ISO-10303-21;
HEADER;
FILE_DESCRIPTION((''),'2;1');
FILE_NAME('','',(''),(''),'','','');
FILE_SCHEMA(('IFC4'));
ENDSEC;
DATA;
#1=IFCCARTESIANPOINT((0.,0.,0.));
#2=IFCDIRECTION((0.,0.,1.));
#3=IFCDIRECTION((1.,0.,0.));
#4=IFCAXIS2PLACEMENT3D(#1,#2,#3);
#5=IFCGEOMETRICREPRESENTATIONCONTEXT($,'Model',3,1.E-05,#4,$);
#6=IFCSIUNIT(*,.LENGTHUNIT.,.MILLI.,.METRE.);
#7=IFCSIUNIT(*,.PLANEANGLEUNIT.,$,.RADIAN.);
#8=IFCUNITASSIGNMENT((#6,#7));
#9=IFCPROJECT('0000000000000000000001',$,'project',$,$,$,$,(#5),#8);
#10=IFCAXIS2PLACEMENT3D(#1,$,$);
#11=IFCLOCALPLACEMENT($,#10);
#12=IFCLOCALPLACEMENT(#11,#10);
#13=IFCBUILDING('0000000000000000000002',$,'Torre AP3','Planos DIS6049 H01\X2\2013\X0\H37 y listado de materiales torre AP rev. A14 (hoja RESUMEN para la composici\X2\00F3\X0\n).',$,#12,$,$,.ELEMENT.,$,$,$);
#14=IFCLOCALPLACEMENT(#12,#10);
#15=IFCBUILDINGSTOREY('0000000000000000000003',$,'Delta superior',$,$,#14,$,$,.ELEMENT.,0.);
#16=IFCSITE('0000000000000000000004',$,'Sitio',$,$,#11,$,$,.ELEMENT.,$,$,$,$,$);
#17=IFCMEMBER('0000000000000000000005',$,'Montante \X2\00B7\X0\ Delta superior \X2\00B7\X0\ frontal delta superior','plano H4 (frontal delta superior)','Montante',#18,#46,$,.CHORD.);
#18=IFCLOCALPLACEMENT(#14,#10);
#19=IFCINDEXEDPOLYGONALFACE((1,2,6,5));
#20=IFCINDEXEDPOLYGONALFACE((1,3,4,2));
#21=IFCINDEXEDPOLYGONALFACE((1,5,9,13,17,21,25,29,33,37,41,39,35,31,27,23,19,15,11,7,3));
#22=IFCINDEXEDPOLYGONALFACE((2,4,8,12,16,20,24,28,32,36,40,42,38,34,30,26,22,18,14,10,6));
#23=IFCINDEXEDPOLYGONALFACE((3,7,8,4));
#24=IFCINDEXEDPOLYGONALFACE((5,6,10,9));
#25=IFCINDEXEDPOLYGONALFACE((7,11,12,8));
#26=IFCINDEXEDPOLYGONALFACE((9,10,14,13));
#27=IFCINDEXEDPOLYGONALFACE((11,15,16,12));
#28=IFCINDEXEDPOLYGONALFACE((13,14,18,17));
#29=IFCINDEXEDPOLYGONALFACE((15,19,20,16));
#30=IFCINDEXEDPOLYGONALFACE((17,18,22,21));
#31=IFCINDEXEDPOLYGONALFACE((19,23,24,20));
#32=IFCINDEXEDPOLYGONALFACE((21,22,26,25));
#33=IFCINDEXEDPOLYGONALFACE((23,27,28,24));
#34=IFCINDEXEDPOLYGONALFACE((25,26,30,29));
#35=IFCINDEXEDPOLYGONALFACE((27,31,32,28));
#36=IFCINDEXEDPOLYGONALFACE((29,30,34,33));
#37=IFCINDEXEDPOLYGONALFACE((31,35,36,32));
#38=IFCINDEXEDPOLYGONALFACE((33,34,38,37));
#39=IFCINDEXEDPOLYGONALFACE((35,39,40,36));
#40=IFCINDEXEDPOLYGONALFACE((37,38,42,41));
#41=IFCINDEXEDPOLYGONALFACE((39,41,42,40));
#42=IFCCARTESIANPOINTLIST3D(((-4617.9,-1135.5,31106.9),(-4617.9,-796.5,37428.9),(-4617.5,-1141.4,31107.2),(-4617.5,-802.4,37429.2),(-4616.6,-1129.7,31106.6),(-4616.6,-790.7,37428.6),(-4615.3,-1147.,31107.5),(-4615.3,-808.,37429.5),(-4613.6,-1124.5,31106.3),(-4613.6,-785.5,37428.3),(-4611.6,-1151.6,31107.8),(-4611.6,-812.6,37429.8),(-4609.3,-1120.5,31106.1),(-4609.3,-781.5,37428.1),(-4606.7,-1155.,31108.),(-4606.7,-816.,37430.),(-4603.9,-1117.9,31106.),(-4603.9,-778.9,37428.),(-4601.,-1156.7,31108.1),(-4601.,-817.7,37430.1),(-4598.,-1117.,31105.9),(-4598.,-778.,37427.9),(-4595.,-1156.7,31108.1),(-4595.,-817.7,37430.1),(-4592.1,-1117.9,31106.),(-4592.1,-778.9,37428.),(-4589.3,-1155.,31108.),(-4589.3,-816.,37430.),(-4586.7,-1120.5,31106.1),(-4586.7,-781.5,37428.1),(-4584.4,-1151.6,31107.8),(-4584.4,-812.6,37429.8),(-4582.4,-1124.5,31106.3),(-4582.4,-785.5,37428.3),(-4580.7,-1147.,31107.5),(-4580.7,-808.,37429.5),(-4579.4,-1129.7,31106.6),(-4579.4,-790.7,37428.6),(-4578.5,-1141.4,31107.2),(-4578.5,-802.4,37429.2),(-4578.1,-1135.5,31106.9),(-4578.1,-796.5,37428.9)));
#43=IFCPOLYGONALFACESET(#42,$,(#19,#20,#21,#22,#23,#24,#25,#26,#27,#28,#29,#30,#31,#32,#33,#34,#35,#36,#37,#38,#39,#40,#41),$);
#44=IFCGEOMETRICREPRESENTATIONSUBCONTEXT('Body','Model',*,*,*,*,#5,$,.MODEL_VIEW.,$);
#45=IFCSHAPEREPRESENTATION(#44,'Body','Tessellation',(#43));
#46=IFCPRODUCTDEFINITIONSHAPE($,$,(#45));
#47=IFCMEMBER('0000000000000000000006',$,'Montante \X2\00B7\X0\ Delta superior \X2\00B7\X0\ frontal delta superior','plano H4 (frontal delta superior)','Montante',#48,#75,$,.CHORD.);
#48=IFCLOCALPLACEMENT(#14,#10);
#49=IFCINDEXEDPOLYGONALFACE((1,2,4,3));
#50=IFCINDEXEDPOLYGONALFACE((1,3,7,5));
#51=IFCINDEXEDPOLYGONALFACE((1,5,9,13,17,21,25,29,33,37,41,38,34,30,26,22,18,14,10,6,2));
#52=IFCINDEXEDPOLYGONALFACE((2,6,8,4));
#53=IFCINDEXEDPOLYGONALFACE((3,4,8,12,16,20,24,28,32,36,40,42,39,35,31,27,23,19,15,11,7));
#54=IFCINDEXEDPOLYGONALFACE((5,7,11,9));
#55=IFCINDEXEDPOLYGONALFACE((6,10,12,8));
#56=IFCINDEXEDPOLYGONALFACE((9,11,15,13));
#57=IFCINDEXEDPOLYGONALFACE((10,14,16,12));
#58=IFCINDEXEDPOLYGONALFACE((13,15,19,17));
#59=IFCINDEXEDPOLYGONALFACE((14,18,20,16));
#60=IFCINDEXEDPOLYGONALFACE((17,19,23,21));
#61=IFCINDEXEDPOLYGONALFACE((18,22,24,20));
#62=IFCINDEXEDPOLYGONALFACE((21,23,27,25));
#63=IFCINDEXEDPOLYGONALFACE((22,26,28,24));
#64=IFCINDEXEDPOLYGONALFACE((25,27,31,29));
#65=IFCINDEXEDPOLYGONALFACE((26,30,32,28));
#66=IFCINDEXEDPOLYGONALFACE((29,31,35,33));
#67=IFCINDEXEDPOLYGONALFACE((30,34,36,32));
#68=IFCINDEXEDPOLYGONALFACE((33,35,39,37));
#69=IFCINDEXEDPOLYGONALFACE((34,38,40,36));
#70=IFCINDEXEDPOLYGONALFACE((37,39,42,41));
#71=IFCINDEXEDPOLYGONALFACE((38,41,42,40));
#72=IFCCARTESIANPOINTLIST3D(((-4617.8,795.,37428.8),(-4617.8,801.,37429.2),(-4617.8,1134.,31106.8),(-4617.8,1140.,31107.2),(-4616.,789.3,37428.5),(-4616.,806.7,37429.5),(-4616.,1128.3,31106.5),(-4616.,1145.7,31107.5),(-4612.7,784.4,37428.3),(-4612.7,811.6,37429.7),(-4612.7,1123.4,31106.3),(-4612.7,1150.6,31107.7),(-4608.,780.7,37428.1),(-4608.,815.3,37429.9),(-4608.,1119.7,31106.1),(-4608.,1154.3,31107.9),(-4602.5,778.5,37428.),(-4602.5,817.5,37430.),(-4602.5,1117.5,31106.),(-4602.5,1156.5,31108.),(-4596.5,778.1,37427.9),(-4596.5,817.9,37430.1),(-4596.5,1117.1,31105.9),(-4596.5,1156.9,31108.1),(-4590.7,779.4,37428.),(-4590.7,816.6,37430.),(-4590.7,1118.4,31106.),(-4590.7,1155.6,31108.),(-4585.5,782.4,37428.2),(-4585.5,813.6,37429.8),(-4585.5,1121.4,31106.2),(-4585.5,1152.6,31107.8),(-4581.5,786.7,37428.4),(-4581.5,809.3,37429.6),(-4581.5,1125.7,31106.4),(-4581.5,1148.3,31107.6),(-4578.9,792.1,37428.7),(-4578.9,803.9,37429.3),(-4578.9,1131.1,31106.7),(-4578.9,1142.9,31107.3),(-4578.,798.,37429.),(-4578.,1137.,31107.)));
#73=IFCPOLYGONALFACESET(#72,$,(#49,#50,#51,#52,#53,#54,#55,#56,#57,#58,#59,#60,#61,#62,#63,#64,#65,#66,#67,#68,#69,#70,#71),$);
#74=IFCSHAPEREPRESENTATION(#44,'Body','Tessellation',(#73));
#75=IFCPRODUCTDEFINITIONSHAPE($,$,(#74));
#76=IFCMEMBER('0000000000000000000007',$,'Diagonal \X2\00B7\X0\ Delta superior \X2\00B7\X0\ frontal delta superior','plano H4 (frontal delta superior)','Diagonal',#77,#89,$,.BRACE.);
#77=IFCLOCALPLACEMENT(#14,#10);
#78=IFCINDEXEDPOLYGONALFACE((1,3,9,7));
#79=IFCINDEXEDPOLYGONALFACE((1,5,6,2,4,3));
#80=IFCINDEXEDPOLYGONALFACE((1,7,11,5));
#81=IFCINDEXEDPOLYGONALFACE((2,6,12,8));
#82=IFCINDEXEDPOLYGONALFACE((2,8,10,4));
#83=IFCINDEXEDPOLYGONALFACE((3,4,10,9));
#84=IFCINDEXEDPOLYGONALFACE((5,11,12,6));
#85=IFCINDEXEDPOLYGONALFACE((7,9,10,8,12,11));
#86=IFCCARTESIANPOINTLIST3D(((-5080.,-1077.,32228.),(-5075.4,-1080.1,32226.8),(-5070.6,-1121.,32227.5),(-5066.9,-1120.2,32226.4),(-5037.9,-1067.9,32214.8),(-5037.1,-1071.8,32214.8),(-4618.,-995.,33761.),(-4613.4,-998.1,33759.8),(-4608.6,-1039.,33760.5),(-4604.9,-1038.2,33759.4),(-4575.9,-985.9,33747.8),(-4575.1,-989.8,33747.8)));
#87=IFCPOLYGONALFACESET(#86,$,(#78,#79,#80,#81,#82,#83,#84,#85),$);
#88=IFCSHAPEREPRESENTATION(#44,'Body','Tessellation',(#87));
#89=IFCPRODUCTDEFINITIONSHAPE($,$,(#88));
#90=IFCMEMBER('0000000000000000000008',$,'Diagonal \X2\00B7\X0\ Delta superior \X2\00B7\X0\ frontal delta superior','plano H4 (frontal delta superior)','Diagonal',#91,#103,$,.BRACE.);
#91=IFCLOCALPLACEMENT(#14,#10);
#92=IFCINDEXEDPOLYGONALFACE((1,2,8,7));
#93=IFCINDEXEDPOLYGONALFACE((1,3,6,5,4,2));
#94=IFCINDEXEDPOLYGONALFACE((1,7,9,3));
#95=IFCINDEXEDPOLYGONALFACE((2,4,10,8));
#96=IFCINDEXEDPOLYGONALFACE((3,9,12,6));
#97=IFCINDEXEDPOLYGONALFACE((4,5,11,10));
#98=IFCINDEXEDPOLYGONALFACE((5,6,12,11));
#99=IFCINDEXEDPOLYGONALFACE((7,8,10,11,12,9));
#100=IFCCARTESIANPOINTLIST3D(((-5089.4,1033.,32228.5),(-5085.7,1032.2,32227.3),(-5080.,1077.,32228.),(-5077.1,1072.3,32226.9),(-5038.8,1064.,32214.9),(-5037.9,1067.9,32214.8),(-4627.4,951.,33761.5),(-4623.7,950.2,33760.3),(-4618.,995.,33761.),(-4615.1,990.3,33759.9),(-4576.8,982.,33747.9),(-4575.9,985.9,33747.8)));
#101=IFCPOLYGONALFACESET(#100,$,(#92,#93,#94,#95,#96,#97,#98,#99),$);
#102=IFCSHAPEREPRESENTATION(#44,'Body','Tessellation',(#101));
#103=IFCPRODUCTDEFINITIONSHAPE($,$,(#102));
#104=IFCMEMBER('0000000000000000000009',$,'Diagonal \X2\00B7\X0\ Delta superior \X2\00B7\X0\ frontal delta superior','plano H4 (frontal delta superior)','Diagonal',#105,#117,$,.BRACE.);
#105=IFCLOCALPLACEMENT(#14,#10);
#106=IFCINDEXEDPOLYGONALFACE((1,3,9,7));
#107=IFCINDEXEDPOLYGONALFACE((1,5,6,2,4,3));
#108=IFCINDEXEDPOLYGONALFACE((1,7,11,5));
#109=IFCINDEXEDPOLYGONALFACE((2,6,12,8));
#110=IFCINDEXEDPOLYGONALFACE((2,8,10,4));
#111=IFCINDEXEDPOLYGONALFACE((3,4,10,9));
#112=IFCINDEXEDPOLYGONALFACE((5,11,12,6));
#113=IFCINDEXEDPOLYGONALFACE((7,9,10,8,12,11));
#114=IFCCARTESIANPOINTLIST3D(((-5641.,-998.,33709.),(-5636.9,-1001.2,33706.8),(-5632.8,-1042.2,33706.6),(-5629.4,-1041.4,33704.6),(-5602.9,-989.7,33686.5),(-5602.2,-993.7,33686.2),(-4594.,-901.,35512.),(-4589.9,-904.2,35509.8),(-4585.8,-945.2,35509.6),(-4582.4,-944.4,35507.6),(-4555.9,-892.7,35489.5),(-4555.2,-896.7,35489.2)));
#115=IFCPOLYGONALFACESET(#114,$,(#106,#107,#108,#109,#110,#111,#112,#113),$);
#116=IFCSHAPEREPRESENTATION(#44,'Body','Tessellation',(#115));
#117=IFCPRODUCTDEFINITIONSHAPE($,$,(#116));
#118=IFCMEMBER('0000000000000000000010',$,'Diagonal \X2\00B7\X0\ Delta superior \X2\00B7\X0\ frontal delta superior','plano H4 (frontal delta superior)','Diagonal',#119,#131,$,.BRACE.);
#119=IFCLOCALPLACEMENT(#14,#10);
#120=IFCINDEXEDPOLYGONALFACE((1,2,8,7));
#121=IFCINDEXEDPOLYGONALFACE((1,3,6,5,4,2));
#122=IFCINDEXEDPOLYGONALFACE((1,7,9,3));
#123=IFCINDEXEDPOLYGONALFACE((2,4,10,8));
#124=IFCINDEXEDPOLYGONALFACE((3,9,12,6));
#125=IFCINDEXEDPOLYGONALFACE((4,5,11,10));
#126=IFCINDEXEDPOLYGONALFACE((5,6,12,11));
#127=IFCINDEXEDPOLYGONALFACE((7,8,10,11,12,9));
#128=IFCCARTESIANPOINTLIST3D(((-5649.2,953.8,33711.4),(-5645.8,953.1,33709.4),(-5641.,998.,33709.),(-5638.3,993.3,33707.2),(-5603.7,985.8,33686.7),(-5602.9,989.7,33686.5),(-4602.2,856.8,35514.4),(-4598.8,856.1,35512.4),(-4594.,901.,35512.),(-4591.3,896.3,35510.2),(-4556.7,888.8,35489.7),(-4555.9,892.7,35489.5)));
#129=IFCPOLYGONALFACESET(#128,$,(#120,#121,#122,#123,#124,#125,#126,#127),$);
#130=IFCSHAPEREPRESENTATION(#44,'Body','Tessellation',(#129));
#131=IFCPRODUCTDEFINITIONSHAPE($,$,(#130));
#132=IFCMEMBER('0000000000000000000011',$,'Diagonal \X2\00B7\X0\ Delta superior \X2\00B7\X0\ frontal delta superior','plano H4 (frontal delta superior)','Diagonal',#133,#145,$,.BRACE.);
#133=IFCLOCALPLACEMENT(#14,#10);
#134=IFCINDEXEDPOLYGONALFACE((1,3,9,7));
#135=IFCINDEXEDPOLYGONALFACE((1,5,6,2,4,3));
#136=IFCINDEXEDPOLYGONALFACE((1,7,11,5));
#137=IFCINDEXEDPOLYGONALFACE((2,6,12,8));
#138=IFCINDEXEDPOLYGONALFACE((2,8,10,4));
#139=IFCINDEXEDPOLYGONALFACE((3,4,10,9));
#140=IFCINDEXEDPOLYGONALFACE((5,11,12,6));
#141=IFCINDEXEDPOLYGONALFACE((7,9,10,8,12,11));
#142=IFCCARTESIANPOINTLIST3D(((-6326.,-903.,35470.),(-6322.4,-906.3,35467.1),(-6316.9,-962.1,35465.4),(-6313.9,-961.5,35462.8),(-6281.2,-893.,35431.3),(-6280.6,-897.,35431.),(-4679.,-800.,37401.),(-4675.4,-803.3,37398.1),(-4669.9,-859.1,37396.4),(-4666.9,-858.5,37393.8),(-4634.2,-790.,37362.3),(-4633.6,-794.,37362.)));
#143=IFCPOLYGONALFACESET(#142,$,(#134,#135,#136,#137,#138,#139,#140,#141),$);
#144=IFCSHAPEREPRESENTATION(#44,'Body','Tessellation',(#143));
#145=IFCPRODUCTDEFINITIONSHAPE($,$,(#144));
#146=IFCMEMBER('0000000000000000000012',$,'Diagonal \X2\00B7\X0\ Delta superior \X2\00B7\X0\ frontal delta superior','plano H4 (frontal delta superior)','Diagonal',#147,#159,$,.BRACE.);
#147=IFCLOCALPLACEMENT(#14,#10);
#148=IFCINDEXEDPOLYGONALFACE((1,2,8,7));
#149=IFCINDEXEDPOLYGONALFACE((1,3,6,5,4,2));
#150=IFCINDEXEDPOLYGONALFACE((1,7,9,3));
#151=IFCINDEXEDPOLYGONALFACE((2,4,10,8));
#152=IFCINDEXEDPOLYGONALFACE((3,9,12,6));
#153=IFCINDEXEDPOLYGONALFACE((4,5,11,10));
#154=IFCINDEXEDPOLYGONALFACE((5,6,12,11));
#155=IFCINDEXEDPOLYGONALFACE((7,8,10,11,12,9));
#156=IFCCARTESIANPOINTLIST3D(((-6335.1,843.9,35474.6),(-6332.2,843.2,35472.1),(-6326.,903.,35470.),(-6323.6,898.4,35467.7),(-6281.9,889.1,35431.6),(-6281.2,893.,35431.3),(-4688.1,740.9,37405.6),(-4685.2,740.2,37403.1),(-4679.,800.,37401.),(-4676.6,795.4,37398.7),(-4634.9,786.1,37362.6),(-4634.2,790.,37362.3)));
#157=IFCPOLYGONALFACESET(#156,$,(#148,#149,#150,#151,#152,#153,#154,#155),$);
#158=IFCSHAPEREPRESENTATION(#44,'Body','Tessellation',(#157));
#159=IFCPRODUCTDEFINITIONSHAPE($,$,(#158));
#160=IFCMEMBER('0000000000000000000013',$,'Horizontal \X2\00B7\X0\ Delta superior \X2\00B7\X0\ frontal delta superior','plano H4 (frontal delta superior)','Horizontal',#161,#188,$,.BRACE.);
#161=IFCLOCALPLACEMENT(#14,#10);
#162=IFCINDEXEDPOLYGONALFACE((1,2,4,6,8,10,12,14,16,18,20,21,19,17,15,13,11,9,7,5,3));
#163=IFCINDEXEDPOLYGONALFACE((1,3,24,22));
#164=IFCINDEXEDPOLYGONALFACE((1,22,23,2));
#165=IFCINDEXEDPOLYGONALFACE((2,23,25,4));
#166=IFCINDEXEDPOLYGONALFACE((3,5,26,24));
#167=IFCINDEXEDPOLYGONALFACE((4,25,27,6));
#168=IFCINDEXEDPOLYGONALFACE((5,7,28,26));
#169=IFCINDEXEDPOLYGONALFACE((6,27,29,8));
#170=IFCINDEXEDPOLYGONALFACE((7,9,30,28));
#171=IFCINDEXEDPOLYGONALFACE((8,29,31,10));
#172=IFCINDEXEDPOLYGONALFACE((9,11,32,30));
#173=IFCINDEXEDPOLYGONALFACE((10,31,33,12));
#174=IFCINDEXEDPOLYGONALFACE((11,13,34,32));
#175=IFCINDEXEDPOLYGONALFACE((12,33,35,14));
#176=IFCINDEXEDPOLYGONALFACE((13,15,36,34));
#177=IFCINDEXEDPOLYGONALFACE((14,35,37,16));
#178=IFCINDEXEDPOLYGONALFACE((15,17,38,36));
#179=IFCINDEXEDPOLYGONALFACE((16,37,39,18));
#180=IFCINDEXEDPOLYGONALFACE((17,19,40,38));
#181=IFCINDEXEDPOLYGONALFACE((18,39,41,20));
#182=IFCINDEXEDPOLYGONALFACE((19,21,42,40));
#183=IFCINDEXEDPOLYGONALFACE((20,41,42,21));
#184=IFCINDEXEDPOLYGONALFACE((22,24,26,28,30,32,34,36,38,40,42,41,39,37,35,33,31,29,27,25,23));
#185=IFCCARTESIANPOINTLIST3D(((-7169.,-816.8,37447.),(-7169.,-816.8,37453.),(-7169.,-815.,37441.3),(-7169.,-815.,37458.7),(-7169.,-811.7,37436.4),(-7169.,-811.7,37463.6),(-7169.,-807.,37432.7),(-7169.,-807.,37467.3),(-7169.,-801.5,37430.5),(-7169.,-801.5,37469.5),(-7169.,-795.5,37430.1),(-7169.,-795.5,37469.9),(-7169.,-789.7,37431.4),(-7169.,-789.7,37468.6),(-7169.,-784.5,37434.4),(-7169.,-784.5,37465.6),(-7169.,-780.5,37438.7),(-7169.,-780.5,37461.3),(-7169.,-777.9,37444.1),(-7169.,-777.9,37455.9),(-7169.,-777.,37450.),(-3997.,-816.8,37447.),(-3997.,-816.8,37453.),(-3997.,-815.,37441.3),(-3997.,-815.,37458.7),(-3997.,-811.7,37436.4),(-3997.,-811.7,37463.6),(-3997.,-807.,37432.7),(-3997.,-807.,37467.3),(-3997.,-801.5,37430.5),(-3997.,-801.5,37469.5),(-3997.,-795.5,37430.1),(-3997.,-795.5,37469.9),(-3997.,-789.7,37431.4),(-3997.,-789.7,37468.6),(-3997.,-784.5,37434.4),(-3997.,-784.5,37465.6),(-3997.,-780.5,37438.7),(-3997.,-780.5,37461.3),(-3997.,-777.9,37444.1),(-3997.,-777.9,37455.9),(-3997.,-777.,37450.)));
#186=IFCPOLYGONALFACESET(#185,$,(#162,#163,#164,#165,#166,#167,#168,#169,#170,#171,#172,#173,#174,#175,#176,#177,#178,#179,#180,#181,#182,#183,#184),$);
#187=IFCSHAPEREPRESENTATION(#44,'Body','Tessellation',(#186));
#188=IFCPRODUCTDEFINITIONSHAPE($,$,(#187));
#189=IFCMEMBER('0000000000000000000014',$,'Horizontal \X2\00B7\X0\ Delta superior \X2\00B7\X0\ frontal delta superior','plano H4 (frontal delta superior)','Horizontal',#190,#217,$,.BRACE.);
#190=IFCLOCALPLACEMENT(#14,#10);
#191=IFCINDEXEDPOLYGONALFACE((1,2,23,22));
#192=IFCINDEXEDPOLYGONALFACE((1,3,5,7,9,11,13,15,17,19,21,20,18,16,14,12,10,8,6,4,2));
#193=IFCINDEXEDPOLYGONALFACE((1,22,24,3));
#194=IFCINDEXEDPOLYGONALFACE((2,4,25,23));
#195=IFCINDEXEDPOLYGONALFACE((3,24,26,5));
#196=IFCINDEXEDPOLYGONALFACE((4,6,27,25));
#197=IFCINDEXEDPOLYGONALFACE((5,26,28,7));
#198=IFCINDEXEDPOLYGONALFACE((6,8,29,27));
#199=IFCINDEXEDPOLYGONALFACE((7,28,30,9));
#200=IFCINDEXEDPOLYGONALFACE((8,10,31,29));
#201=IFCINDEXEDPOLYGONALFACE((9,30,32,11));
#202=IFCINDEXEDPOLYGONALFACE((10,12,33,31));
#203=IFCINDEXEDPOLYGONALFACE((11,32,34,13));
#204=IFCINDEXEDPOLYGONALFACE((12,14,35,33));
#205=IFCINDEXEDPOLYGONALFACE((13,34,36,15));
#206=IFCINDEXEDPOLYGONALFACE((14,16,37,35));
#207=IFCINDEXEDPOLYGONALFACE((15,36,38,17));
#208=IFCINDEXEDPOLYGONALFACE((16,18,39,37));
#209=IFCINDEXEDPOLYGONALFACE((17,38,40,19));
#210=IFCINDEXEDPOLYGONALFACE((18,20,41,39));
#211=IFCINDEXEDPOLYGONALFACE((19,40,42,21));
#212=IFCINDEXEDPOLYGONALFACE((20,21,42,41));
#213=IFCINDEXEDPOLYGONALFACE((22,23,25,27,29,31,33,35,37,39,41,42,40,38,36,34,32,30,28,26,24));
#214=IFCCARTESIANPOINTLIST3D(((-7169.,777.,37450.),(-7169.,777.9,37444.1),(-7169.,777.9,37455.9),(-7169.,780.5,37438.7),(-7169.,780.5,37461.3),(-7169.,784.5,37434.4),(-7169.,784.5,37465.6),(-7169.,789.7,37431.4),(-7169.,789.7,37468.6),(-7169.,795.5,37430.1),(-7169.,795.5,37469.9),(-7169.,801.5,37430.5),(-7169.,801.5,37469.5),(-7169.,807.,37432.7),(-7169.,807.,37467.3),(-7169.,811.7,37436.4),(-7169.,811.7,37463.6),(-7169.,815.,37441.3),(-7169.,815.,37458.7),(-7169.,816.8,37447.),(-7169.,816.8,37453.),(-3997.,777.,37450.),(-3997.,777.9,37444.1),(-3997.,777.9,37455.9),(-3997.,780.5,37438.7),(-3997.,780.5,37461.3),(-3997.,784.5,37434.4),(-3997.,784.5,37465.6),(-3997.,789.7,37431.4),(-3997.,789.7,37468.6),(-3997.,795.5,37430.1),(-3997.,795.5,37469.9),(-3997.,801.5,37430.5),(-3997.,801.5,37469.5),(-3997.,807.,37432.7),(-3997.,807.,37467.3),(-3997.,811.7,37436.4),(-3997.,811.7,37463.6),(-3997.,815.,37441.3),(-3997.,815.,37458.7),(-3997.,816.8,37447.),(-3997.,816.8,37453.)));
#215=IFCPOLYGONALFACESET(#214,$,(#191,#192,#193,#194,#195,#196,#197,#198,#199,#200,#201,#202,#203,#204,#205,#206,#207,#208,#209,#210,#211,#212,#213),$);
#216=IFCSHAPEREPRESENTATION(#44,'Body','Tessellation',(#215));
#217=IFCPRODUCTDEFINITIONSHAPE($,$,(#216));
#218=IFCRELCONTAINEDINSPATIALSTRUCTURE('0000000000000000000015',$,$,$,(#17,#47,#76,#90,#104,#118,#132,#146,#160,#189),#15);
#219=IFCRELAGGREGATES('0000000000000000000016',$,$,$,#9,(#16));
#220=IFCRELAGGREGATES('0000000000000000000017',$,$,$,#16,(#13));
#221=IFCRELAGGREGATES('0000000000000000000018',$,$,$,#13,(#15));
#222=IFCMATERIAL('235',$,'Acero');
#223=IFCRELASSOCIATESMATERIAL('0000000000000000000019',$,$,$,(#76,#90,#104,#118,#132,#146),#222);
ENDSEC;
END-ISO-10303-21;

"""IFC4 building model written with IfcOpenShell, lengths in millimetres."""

from ifc_helpers import new_model, si_unit, frame, frame_2d, origin, origin_with_axes, place, context, subcontext, project, spatial, circle, l_section, extrude, material, element, save


model = new_model("IFC4")

# Units and contexts
model_context = context("Model", 3, precision=1e-05, world=origin_with_axes())
body_context = subcontext(model_context, "Body", "Model", "MODEL_VIEW")
ifc_project = project(units=[si_unit("LENGTHUNIT", "METRE", prefix="MILLI"), si_unit("PLANEANGLEUNIT", "RADIAN")], contexts=[model_context])

# Site, building, storey
site_placement = place(None, origin())
site = spatial("IfcSite", under=ifc_project, at=site_placement, Name="Sitio", CompositionType="ELEMENT")
building_placement = place(site_placement, origin())
building = spatial("IfcBuilding", under=site, at=building_placement, Name="Torre AP3", Description="Planos DIS6049 H01–H37 y listado de materiales torre AP rev. A14 (hoja RESUMEN para la composición).", CompositionType="ELEMENT")
storey_placement = place(building_placement, origin())
storey = spatial("IfcBuildingStorey", under=building, at=storey_placement, Name="Delta superior", CompositionType="ELEMENT", Elevation=0.0)

# Members
for number, where, z_axis, x_axis, name in (
    (1, (-4598.0, -798.0, 37429.0), (0.0, -0.053545, -0.998565), (0.0, 0.998565, -0.053545), "Montante · Delta superior · frontal delta superior"),
    (2, (-4598.0, 798.0, 37429.0), (0.0, 0.053545, -0.998565), (1.0, 0.0, 0.0), "Montante · Delta superior · frontal delta superior"),
):
    element("IfcMember", number, at=place(storey_placement, frame(where, z_axis=z_axis, x_axis=x_axis)), inside=storey, Name=name, Description="plano H4 (frontal delta superior)", ObjectType="Montante", PredefinedType="CHORD", context=body_context, shape_type="SweptSolid", body=[
        extrude(circle(Radius=20.0), None, (0.0, 0.0, 1.0), 6331.1),
    ])
ifc_material_1 = material(Name="235", Category="Acero")
for number, where, z_axis, x_axis, name in (
    (3, (-4618.0, -995.0, 33761.0), (-0.288173, -0.051148, -0.956211), (0.934509, 0.202848, -0.292483), "Diagonal · Delta superior · frontal delta superior"),
    (4, (-4618.0, 995.0, 33761.0), (-0.288173, 0.051148, -0.956211), (0.934509, -0.202848, -0.292483), "Diagonal · Delta superior · frontal delta superior"),
):
    element("IfcMember", number, at=place(storey_placement, frame(where, z_axis=z_axis, x_axis=x_axis)), inside=storey, material=ifc_material_1, Name=name, Description="plano H4 (frontal delta superior)", ObjectType="Diagonal", PredefinedType="BRACE", context=body_context, shape_type="SweptSolid", body=[
        extrude(l_section(Depth=45.0, Width=45.0, Thickness=4.0, at=frame_2d((22.5, 22.5))), None, (0.0, 0.0, 1.0), 1603.2),
    ])
for number, where, z_axis, x_axis, name in (
    (5, (-4594.0, -901.0, 35512.0), (-0.501628, -0.046474, -0.863834), (0.845685, 0.183933, -0.500984), "Diagonal · Delta superior · frontal delta superior"),
    (6, (-4594.0, 901.0, 35512.0), (-0.501628, 0.046474, -0.863834), (0.845685, -0.183933, -0.500984), "Diagonal · Delta superior · frontal delta superior"),
):
    element("IfcMember", number, at=place(storey_placement, frame(where, z_axis=z_axis, x_axis=x_axis)), inside=storey, material=ifc_material_1, Name=name, Description="plano H4 (frontal delta superior)", ObjectType="Diagonal", PredefinedType="BRACE", context=body_context, shape_type="SweptSolid", body=[
        extrude(l_section(Depth=45.0, Width=45.0, Thickness=4.0, at=frame_2d((22.5, 22.5))), None, (0.0, 0.0, 1.0), 2087.2),
    ])
for number, where, z_axis, x_axis, name in (
    (7, (-4679.0, -800.0, 37401.0), (-0.648406, -0.04055, -0.760214), (0.745871, 0.166153, -0.645035), "Diagonal · Delta superior · frontal delta superior"),
    (8, (-4679.0, 800.0, 37401.0), (-0.648406, 0.04055, -0.760214), (0.745871, -0.166153, -0.645035), "Diagonal · Delta superior · frontal delta superior"),
):
    element("IfcMember", number, at=place(storey_placement, frame(where, z_axis=z_axis, x_axis=x_axis)), inside=storey, material=ifc_material_1, Name=name, Description="plano H4 (frontal delta superior)", ObjectType="Diagonal", PredefinedType="BRACE", context=body_context, shape_type="SweptSolid", body=[
        extrude(l_section(Depth=60.0, Width=60.0, Thickness=4.0, at=frame_2d((30.0, 30.0))), None, (0.0, 0.0, 1.0), 2540.1),
    ])
for number, where, z_axis, x_axis, name in (
    (9, (-3997.0, -797.0, 37450.0), (-1.0, 0.0, 0.0), (0.0, 1.0, 0.0), "Horizontal · Delta superior · frontal delta superior"),
    (10, (-3997.0, 797.0, 37450.0), (-1.0, 0.0, 0.0), (0.0, -1.0, 0.0), "Horizontal · Delta superior · frontal delta superior"),
):
    element("IfcMember", number, at=place(storey_placement, frame(where, z_axis=z_axis, x_axis=x_axis)), inside=storey, Name=name, Description="plano H4 (frontal delta superior)", ObjectType="Horizontal", PredefinedType="BRACE", context=body_context, shape_type="SweptSolid", body=[
        extrude(circle(Radius=20.0), None, (0.0, 0.0, 1.0), 3172.0),
    ])

save(model, "model.ifc")
